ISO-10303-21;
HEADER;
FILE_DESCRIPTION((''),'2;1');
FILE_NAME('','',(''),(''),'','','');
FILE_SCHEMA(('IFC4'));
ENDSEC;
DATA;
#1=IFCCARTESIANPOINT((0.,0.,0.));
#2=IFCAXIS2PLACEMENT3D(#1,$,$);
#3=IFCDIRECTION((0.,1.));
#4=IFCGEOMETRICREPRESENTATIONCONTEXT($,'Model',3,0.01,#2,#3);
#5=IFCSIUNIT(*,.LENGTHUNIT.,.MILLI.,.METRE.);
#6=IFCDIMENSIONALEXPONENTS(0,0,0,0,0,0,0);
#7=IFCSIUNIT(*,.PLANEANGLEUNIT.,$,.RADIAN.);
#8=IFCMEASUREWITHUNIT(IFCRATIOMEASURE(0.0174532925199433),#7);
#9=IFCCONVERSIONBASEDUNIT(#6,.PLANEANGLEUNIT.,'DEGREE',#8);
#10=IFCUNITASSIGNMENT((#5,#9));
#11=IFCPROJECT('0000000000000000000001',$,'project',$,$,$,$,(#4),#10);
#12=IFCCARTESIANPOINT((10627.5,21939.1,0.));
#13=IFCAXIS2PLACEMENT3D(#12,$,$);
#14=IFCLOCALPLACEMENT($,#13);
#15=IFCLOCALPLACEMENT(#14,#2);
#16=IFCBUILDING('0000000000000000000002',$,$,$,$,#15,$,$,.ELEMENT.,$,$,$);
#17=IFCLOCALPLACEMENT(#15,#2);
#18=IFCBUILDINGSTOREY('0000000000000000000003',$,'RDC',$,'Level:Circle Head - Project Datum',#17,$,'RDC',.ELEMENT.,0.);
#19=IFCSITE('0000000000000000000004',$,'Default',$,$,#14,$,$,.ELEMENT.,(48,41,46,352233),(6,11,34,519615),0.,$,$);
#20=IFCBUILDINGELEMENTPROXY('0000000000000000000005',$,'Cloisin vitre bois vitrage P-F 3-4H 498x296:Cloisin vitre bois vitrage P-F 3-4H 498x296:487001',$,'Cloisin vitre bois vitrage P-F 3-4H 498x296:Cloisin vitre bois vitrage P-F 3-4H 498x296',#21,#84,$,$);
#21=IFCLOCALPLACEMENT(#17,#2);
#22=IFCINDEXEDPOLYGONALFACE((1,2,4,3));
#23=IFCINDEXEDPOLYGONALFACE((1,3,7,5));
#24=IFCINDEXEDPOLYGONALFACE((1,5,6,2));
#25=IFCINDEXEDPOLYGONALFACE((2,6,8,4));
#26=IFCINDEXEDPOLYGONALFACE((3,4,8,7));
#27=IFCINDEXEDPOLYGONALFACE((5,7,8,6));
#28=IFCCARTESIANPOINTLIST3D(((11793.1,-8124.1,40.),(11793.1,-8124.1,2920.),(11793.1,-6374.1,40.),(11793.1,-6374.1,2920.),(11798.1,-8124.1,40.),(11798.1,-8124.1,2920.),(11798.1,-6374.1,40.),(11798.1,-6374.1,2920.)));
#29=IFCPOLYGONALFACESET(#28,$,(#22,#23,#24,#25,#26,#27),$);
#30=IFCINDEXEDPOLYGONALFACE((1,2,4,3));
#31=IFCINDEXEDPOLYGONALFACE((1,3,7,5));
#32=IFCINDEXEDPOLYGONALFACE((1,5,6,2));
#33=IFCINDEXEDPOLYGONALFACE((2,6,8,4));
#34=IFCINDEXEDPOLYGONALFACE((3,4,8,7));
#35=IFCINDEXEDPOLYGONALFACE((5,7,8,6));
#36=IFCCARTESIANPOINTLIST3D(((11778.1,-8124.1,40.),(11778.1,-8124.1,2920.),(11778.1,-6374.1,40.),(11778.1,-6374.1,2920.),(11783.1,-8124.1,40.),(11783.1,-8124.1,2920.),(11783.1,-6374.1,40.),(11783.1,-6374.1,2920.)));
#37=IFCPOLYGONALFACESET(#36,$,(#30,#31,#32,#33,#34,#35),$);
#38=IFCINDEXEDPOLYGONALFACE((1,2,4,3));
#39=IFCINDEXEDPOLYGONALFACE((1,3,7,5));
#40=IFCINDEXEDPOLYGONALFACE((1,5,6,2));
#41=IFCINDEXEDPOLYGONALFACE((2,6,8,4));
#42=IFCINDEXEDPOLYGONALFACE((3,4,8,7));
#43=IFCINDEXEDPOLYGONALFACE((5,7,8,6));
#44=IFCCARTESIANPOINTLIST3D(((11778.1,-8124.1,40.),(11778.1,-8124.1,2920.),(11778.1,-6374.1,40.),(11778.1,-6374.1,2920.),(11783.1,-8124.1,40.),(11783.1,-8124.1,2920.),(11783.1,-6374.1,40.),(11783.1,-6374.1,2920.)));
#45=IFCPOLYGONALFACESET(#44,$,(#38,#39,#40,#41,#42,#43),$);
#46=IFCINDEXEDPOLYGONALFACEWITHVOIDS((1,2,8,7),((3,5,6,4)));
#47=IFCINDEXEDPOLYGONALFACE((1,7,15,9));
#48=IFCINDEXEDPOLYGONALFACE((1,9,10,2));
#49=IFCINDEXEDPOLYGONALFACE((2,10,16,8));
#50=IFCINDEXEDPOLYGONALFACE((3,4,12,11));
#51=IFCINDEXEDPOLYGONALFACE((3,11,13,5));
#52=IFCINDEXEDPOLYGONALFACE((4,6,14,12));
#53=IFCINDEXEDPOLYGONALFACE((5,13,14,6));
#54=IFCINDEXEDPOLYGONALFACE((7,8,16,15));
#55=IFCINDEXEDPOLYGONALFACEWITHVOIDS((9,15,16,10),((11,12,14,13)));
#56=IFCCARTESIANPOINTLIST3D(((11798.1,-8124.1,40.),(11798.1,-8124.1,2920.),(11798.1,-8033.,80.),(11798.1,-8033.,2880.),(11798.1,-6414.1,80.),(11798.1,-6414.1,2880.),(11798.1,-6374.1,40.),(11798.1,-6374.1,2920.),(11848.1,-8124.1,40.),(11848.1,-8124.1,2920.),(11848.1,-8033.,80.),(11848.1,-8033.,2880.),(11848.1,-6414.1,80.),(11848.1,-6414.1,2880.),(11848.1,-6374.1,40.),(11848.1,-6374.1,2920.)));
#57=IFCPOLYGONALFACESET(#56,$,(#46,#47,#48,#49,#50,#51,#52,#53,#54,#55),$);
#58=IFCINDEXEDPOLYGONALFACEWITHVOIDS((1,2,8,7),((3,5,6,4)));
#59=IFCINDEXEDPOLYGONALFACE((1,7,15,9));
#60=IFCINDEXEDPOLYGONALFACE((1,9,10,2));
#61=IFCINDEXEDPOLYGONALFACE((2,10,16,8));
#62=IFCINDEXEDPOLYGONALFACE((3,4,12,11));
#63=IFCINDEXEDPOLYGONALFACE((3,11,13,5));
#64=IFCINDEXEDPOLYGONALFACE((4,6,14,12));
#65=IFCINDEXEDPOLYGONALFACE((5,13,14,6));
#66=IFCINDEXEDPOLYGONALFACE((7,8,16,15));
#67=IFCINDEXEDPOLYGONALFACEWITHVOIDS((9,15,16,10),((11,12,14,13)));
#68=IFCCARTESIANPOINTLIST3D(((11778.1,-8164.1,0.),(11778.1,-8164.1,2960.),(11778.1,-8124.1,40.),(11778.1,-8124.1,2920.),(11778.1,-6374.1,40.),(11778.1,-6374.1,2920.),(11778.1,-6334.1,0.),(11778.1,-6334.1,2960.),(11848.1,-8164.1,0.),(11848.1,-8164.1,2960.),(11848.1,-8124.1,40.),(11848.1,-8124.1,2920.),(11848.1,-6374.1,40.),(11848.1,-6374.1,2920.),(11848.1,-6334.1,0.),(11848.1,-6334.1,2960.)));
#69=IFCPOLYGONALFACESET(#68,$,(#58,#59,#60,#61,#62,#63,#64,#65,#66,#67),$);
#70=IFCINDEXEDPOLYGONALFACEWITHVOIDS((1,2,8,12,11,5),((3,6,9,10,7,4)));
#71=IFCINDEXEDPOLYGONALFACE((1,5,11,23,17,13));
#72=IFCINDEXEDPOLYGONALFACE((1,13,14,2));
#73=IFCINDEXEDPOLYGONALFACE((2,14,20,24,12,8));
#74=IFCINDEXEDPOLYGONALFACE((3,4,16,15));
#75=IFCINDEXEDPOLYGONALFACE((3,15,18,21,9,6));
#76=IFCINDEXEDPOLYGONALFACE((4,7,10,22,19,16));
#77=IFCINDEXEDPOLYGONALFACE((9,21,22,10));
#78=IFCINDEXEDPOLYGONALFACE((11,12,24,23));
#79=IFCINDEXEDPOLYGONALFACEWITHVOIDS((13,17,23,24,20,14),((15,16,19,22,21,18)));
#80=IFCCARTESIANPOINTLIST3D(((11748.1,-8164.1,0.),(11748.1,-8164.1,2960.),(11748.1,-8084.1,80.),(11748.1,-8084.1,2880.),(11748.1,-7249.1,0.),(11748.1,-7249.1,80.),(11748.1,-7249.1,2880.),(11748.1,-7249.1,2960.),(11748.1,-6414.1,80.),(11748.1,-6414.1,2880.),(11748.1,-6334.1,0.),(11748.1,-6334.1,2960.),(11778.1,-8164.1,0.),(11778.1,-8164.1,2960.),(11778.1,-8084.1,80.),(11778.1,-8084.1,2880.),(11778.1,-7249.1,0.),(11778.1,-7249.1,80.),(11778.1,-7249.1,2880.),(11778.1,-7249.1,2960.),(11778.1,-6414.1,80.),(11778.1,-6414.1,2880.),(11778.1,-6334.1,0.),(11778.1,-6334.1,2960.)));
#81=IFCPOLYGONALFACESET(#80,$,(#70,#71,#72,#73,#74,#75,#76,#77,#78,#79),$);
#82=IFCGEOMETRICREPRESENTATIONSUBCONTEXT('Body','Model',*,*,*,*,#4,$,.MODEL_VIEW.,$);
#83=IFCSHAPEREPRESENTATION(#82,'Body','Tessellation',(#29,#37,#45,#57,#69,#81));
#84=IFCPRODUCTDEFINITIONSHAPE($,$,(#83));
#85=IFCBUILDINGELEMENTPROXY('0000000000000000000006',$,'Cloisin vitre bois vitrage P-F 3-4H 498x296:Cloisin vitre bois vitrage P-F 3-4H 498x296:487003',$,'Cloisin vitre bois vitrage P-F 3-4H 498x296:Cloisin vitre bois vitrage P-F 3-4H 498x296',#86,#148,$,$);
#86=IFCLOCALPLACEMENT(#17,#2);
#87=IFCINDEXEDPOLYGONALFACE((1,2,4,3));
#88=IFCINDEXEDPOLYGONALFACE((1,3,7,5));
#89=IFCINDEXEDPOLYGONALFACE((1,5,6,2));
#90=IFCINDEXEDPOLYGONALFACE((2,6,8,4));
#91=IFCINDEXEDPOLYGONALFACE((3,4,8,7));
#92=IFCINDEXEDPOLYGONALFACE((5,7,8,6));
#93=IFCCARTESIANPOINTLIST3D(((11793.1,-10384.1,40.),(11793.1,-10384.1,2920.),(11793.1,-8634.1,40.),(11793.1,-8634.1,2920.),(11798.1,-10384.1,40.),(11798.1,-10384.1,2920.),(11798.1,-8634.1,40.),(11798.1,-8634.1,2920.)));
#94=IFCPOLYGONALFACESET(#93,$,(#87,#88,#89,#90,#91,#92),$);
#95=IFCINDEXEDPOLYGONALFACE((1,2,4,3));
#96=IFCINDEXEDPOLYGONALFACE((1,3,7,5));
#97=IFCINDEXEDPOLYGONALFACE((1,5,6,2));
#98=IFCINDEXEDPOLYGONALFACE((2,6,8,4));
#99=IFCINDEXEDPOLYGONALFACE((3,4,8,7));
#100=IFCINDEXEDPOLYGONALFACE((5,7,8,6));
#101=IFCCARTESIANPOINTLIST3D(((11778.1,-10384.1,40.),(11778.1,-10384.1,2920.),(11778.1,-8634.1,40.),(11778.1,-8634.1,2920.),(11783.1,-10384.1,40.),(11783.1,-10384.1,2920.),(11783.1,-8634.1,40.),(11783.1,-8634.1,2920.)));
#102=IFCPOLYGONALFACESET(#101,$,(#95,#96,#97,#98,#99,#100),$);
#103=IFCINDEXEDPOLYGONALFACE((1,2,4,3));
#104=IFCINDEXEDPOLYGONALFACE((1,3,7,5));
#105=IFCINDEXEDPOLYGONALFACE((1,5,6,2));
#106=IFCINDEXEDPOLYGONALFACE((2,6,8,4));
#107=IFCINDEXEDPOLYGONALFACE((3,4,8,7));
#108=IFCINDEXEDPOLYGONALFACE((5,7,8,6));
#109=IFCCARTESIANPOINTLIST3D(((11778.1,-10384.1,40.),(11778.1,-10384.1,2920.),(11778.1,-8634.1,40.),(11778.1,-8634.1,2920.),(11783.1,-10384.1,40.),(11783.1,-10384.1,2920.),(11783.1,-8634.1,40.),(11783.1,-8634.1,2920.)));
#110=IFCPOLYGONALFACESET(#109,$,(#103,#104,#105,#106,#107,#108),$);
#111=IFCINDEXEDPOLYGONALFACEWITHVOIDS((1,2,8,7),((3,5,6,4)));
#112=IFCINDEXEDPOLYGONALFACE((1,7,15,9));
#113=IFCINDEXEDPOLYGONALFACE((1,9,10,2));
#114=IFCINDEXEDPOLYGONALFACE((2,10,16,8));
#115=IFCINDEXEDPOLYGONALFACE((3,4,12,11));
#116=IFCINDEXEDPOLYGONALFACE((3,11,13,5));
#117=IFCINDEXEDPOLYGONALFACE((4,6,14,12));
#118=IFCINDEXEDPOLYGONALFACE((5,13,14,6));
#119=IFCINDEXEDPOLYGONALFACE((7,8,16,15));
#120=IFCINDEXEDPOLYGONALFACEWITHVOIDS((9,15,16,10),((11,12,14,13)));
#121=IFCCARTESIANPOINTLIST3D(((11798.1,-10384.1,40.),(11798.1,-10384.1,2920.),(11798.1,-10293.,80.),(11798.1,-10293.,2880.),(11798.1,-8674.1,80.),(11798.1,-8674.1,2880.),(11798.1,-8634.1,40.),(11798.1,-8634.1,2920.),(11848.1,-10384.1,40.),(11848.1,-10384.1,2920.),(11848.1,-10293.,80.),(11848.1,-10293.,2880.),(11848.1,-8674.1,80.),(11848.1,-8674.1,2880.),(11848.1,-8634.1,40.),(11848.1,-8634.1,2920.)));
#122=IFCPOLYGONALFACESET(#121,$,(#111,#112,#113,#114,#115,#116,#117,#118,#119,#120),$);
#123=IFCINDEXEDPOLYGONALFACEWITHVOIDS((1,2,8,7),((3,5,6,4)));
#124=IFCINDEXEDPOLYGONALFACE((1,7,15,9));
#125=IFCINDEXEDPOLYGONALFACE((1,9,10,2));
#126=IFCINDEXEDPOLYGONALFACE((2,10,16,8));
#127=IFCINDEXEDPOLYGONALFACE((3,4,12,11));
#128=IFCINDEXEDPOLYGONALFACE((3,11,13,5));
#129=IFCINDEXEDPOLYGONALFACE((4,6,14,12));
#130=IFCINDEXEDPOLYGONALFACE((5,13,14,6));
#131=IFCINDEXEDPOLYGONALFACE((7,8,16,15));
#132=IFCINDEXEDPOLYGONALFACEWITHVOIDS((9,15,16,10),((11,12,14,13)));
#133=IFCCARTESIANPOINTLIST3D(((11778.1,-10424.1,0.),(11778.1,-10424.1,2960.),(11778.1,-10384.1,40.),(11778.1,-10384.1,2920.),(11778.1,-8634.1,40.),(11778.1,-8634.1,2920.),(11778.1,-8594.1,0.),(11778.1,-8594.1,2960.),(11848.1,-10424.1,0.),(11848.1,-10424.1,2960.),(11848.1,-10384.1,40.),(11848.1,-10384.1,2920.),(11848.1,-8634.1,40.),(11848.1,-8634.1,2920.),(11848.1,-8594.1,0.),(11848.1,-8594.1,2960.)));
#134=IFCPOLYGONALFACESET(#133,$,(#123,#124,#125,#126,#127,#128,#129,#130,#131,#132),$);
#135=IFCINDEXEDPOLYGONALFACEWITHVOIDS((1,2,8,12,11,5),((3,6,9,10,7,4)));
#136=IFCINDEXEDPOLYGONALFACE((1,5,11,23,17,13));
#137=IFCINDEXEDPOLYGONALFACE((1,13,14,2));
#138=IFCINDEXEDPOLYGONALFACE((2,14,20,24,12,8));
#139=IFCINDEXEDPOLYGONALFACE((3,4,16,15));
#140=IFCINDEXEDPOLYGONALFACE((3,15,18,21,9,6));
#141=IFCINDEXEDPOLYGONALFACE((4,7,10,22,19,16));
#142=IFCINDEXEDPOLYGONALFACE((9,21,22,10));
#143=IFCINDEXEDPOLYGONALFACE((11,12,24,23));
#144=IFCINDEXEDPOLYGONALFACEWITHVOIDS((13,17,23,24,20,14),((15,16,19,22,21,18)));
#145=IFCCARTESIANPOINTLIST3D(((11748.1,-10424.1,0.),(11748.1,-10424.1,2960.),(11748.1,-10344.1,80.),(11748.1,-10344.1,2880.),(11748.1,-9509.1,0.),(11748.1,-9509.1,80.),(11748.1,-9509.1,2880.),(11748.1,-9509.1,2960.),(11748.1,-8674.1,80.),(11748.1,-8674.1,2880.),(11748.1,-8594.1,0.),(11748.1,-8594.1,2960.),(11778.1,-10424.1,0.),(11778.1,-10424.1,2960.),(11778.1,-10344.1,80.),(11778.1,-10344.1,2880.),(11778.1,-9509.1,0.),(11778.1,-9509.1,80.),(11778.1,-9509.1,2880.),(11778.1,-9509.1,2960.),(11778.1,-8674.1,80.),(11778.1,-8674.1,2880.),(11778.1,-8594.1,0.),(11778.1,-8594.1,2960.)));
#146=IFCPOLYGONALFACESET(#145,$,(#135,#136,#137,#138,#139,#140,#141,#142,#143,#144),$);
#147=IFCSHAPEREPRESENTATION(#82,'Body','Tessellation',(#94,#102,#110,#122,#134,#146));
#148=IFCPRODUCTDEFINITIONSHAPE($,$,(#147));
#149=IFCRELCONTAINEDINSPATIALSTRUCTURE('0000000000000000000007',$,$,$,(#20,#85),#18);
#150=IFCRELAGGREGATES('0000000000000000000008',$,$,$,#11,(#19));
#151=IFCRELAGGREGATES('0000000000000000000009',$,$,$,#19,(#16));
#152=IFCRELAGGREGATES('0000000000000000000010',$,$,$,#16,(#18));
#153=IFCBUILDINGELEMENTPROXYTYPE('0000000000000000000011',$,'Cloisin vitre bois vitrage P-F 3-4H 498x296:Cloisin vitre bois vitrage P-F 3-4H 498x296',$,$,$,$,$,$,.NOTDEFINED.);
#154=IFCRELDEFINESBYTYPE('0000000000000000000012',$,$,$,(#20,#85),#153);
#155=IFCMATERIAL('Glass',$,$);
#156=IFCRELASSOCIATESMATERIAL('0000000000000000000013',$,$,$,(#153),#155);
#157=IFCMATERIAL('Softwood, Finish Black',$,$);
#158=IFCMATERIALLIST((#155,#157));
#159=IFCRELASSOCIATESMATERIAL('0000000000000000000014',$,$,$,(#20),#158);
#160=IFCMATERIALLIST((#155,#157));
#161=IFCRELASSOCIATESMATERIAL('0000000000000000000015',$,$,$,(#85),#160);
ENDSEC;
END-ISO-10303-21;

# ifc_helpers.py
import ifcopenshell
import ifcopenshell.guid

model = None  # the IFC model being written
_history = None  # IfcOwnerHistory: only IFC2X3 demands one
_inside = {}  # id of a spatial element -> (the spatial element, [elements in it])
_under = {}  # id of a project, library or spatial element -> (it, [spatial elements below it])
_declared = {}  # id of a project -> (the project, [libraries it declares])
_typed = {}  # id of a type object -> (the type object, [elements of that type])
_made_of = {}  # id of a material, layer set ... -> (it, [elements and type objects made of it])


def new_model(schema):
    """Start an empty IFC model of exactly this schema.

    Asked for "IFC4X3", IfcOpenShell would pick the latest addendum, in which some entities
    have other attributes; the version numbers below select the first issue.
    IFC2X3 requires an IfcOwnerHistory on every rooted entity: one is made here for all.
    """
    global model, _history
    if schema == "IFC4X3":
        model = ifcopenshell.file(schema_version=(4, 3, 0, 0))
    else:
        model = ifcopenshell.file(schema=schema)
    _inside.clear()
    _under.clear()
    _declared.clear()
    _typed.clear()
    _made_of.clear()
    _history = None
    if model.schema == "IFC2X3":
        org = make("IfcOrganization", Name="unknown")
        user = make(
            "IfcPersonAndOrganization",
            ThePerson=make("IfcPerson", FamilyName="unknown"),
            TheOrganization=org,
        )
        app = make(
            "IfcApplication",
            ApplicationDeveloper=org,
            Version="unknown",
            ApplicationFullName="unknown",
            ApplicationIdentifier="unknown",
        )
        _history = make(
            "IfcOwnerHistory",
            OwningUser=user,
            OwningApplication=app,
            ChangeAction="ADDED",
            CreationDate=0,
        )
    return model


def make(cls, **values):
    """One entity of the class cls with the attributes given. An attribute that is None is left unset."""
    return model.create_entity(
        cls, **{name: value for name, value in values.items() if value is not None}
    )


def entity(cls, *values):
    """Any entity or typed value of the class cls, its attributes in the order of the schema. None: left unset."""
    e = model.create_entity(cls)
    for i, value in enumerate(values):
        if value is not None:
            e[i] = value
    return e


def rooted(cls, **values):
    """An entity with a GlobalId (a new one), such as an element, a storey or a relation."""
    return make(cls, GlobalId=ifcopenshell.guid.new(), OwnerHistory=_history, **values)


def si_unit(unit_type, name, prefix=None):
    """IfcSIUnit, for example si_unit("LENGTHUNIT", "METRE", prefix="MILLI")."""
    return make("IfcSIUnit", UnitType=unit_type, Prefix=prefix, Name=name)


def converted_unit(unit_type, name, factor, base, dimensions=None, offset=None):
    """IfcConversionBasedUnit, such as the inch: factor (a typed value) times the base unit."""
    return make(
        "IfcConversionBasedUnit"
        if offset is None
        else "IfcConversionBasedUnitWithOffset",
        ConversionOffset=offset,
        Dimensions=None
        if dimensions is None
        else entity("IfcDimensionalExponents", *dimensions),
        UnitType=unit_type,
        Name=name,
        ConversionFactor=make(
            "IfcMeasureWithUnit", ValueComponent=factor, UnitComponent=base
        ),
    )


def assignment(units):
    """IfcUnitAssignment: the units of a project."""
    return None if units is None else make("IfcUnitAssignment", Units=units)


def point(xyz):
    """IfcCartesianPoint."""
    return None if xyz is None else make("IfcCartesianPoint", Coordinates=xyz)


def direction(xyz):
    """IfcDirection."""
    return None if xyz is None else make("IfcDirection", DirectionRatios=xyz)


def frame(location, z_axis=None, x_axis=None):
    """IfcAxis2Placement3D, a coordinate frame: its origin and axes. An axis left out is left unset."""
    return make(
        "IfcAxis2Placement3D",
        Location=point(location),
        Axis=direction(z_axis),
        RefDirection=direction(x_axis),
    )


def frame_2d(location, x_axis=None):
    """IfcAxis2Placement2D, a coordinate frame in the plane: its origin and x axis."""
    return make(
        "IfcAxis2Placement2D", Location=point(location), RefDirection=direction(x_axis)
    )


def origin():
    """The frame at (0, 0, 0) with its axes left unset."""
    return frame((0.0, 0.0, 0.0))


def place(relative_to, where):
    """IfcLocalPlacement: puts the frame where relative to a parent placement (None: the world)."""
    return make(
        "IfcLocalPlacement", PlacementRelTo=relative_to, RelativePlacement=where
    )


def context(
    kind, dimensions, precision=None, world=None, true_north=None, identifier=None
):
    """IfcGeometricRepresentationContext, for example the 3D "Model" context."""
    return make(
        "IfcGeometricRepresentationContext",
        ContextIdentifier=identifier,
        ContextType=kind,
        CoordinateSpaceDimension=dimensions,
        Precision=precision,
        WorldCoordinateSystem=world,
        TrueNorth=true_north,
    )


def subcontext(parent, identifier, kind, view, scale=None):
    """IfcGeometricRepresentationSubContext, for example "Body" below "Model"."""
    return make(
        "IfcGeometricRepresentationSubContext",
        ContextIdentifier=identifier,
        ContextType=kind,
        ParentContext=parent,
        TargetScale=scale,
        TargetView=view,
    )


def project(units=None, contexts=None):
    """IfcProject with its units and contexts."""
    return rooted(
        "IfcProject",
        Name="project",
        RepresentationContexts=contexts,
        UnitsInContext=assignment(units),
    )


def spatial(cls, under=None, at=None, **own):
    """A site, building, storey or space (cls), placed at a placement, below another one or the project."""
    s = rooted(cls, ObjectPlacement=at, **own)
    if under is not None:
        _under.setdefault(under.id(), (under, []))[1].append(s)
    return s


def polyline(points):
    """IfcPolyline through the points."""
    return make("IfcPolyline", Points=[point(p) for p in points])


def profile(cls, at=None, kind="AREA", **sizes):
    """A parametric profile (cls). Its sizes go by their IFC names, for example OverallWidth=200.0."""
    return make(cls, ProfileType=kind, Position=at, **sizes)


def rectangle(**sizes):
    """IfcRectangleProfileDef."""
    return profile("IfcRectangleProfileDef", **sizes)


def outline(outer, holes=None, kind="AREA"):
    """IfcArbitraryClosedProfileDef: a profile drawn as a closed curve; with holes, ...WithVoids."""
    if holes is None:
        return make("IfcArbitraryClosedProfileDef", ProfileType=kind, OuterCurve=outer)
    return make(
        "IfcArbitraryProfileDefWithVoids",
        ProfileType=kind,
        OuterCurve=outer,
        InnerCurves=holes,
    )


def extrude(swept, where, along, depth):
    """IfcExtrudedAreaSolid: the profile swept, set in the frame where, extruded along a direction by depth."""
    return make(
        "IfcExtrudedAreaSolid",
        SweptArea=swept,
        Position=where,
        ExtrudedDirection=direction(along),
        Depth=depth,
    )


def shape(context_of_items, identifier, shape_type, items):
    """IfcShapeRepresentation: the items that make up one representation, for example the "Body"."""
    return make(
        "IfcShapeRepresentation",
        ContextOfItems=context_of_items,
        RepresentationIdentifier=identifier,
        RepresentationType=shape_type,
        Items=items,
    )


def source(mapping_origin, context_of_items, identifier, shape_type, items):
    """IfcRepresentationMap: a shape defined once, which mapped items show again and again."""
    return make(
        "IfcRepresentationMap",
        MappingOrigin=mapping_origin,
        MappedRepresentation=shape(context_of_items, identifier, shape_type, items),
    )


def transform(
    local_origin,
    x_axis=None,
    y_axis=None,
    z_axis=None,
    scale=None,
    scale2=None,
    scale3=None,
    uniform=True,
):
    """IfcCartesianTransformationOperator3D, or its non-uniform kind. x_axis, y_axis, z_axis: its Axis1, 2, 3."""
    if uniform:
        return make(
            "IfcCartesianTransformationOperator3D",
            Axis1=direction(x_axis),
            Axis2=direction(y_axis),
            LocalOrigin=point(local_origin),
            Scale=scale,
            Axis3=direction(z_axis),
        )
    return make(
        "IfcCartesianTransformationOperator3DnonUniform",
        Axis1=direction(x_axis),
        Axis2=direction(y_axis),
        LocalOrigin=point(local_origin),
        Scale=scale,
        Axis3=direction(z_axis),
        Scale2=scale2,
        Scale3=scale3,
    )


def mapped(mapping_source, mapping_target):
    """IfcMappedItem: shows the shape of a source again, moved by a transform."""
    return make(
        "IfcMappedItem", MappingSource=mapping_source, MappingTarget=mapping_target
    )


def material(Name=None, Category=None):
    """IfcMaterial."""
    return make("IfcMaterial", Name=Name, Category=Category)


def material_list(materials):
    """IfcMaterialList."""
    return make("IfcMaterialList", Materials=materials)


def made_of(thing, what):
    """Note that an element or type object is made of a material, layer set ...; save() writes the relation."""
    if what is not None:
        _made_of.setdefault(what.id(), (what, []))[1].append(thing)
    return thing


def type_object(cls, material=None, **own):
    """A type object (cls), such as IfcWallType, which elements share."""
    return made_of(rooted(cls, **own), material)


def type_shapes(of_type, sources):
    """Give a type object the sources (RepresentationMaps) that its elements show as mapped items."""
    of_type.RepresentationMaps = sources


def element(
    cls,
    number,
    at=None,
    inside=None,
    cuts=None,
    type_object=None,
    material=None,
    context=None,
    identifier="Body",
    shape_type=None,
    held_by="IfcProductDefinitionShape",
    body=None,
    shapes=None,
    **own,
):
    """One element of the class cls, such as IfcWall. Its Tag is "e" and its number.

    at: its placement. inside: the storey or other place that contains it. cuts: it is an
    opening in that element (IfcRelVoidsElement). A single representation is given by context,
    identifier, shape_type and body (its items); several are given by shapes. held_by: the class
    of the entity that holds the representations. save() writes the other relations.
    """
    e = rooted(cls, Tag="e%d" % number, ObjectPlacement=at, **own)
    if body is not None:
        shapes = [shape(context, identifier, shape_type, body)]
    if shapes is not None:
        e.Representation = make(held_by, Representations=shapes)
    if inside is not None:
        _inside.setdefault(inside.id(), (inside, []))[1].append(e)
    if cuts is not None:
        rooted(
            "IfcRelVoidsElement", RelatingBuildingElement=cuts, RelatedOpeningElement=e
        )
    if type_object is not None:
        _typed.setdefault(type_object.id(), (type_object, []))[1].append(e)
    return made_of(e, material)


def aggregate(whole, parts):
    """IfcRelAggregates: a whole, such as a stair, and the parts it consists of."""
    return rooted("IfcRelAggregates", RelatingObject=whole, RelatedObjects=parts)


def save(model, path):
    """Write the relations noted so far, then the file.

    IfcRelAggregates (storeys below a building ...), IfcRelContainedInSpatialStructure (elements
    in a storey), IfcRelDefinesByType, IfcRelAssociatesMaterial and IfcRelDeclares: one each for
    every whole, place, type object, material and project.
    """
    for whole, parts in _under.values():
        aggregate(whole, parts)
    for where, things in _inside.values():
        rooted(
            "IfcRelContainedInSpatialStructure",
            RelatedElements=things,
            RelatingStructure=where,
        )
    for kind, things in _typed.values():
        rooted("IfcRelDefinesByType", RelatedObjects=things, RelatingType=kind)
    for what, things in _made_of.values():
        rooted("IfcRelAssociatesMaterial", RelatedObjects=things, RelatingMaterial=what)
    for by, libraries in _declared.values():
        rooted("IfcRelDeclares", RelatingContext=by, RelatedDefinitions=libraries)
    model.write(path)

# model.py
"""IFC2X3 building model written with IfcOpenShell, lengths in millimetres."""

from ifc_helpers import new_model, entity, si_unit, converted_unit, direction, frame, frame_2d, origin, place, context, subcontext, project, spatial, polyline, rectangle, outline, extrude, source, transform, mapped, material, material_list, type_object, type_shapes, element, save


model = new_model("IFC2X3")

# Units and contexts
model_context = context("Model", 3, precision=0.01, world=origin(), true_north=direction((0.0, 1.0)))
body_context = subcontext(model_context, "Body", "Model", "MODEL_VIEW")
ifc_project = project(units=[si_unit("LENGTHUNIT", "METRE", prefix="MILLI"), converted_unit("PLANEANGLEUNIT", "DEGREE", entity("IfcRatioMeasure", 0.0174532925199433), si_unit("PLANEANGLEUNIT", "RADIAN"), dimensions=[0, 0, 0, 0, 0, 0, 0])], contexts=[model_context])

# Site, building, storey
site_placement = place(None, frame((10627.5, 21939.1, 0.0)))
site = spatial("IfcSite", under=ifc_project, at=site_placement, Name="Default", CompositionType="ELEMENT", RefLatitude=(48, 41, 46, 352233), RefLongitude=(6, 11, 34, 519615), RefElevation=0.0)
building_placement = place(site_placement, origin())
building = spatial("IfcBuilding", under=site, at=building_placement, CompositionType="ELEMENT")
storey_placement = place(building_placement, origin())
storey = spatial("IfcBuildingStorey", under=building, at=storey_placement, Name="RDC", ObjectType="Level:Circle Head - Project Datum", LongName="RDC", CompositionType="ELEMENT", Elevation=0.0)

# Building element proxies
ifc_material_1 = material(Name="Glass")
ifc_material_2 = material(Name="Softwood, Finish Black")
building_element_proxy_type_1 = type_object("IfcBuildingElementProxyType", Name="Cloisin vitre bois vitrage P-F 3-4H 498x296:Cloisin vitre bois vitrage P-F 3-4H 498x296", PredefinedType="NOTDEFINED", material=ifc_material_1)
shared_shape_1 = source(origin(), body_context, "Body", "SweptSolid", [
    extrude(rectangle(XDim=1750.0, YDim=5.0, at=frame_2d((0.0, 0.0), x_axis=(1.0, 0.0))), frame((0.0, 47.5, 40.0), z_axis=(0.0, 0.0, 1.0), x_axis=(-1.0, 0.0, 0.0)), (0.0, 0.0, 1.0), 2880.0),
    extrude(rectangle(XDim=1750.0, YDim=5.0, at=frame_2d((0.0, 0.0), x_axis=(1.0, 0.0))), frame((0.0, 32.5, 40.0), z_axis=(0.0, 0.0, 1.0), x_axis=(-1.0, 0.0, 0.0)), (0.0, 0.0, 1.0), 2880.0),
    extrude(rectangle(XDim=1750.0, YDim=5.0, at=frame_2d((0.0, 0.0), x_axis=(1.0, 0.0))), frame((0.0, 32.5, 40.0), z_axis=(0.0, 0.0, 1.0), x_axis=(-1.0, 0.0, 0.0)), (0.0, 0.0, 1.0), 2880.0),
    extrude(outline(polyline([(-1440.0, -875.0), (1440.0, -875.0), (1440.0, 875.0), (-1440.0, 875.0), (-1440.0, -875.0)]), holes=[polyline([(1400.0, 835.0), (1400.0, -783.9), (-1400.0, -783.9), (-1400.0, 835.0), (1400.0, 835.0)])]), frame((0.0, 50.0, 1480.0), z_axis=(0.0, 1.0, 0.0), x_axis=(0.0, 0.0, -1.0)), (0.0, 0.0, 1.0), 50.0),
    extrude(outline(polyline([(-1480.0, -915.0), (1480.0, -915.0), (1480.0, 915.0), (-1480.0, 915.0), (-1480.0, -915.0)]), holes=[polyline([(-1440.0, -875.0), (-1440.0, 875.0), (1440.0, 875.0), (1440.0, -875.0), (-1440.0, -875.0)])]), frame((0.0, 30.0, 1480.0), z_axis=(0.0, 1.0, 0.0), x_axis=(0.0, 0.0, -1.0)), (0.0, 0.0, 1.0), 70.0),
    extrude(outline(polyline([(-1480.0, -915.0), (1480.0, -915.0), (1480.0, 0.0), (1480.0, 915.0), (-1480.0, 915.0), (-1480.0, 0.0), (-1480.0, -915.0)]), holes=[polyline([(1400.0, 0.0), (1400.0, -835.0), (-1400.0, -835.0), (-1400.0, 0.0), (-1400.0, 835.0), (1400.0, 835.0), (1400.0, 0.0)])]), frame((0.0, 0.0, 1480.0), z_axis=(0.0, 1.0, 0.0), x_axis=(0.0, 0.0, 1.0)), (0.0, 0.0, 1.0), 30.0),
])
type_shapes(building_element_proxy_type_1, [shared_shape_1])
ifc_material_list_1 = material_list([ifc_material_1, ifc_material_2])
proxy_1_placement = place(storey_placement, frame((11748.1, -7249.1, 0.0), z_axis=(0.0, 0.0, 1.0), x_axis=(0.0, -1.0, 0.0)))
element("IfcBuildingElementProxy", 1, at=proxy_1_placement, inside=storey, type_object=building_element_proxy_type_1, material=ifc_material_list_1, Name="Cloisin vitre bois vitrage P-F 3-4H 498x296:Cloisin vitre bois vitrage P-F 3-4H 498x296:487001", ObjectType="Cloisin vitre bois vitrage P-F 3-4H 498x296:Cloisin vitre bois vitrage P-F 3-4H 498x296", context=body_context, shape_type="MappedRepresentation", body=[
    mapped(shared_shape_1, transform((0.0, 0.0, 0.0), scale=1.0)),
])
ifc_material_list_2 = material_list([ifc_material_1, ifc_material_2])
proxy_2_placement = place(storey_placement, frame((11748.1, -9509.1, 0.0), z_axis=(0.0, 0.0, 1.0), x_axis=(0.0, -1.0, 0.0)))
element("IfcBuildingElementProxy", 2, at=proxy_2_placement, inside=storey, type_object=building_element_proxy_type_1, material=ifc_material_list_2, Name="Cloisin vitre bois vitrage P-F 3-4H 498x296:Cloisin vitre bois vitrage P-F 3-4H 498x296:487003", ObjectType="Cloisin vitre bois vitrage P-F 3-4H 498x296:Cloisin vitre bois vitrage P-F 3-4H 498x296", context=body_context, shape_type="MappedRepresentation", body=[
    mapped(shared_shape_1, transform((0.0, 0.0, 0.0), scale=1.0)),
])

save(model, "model.ifc")
